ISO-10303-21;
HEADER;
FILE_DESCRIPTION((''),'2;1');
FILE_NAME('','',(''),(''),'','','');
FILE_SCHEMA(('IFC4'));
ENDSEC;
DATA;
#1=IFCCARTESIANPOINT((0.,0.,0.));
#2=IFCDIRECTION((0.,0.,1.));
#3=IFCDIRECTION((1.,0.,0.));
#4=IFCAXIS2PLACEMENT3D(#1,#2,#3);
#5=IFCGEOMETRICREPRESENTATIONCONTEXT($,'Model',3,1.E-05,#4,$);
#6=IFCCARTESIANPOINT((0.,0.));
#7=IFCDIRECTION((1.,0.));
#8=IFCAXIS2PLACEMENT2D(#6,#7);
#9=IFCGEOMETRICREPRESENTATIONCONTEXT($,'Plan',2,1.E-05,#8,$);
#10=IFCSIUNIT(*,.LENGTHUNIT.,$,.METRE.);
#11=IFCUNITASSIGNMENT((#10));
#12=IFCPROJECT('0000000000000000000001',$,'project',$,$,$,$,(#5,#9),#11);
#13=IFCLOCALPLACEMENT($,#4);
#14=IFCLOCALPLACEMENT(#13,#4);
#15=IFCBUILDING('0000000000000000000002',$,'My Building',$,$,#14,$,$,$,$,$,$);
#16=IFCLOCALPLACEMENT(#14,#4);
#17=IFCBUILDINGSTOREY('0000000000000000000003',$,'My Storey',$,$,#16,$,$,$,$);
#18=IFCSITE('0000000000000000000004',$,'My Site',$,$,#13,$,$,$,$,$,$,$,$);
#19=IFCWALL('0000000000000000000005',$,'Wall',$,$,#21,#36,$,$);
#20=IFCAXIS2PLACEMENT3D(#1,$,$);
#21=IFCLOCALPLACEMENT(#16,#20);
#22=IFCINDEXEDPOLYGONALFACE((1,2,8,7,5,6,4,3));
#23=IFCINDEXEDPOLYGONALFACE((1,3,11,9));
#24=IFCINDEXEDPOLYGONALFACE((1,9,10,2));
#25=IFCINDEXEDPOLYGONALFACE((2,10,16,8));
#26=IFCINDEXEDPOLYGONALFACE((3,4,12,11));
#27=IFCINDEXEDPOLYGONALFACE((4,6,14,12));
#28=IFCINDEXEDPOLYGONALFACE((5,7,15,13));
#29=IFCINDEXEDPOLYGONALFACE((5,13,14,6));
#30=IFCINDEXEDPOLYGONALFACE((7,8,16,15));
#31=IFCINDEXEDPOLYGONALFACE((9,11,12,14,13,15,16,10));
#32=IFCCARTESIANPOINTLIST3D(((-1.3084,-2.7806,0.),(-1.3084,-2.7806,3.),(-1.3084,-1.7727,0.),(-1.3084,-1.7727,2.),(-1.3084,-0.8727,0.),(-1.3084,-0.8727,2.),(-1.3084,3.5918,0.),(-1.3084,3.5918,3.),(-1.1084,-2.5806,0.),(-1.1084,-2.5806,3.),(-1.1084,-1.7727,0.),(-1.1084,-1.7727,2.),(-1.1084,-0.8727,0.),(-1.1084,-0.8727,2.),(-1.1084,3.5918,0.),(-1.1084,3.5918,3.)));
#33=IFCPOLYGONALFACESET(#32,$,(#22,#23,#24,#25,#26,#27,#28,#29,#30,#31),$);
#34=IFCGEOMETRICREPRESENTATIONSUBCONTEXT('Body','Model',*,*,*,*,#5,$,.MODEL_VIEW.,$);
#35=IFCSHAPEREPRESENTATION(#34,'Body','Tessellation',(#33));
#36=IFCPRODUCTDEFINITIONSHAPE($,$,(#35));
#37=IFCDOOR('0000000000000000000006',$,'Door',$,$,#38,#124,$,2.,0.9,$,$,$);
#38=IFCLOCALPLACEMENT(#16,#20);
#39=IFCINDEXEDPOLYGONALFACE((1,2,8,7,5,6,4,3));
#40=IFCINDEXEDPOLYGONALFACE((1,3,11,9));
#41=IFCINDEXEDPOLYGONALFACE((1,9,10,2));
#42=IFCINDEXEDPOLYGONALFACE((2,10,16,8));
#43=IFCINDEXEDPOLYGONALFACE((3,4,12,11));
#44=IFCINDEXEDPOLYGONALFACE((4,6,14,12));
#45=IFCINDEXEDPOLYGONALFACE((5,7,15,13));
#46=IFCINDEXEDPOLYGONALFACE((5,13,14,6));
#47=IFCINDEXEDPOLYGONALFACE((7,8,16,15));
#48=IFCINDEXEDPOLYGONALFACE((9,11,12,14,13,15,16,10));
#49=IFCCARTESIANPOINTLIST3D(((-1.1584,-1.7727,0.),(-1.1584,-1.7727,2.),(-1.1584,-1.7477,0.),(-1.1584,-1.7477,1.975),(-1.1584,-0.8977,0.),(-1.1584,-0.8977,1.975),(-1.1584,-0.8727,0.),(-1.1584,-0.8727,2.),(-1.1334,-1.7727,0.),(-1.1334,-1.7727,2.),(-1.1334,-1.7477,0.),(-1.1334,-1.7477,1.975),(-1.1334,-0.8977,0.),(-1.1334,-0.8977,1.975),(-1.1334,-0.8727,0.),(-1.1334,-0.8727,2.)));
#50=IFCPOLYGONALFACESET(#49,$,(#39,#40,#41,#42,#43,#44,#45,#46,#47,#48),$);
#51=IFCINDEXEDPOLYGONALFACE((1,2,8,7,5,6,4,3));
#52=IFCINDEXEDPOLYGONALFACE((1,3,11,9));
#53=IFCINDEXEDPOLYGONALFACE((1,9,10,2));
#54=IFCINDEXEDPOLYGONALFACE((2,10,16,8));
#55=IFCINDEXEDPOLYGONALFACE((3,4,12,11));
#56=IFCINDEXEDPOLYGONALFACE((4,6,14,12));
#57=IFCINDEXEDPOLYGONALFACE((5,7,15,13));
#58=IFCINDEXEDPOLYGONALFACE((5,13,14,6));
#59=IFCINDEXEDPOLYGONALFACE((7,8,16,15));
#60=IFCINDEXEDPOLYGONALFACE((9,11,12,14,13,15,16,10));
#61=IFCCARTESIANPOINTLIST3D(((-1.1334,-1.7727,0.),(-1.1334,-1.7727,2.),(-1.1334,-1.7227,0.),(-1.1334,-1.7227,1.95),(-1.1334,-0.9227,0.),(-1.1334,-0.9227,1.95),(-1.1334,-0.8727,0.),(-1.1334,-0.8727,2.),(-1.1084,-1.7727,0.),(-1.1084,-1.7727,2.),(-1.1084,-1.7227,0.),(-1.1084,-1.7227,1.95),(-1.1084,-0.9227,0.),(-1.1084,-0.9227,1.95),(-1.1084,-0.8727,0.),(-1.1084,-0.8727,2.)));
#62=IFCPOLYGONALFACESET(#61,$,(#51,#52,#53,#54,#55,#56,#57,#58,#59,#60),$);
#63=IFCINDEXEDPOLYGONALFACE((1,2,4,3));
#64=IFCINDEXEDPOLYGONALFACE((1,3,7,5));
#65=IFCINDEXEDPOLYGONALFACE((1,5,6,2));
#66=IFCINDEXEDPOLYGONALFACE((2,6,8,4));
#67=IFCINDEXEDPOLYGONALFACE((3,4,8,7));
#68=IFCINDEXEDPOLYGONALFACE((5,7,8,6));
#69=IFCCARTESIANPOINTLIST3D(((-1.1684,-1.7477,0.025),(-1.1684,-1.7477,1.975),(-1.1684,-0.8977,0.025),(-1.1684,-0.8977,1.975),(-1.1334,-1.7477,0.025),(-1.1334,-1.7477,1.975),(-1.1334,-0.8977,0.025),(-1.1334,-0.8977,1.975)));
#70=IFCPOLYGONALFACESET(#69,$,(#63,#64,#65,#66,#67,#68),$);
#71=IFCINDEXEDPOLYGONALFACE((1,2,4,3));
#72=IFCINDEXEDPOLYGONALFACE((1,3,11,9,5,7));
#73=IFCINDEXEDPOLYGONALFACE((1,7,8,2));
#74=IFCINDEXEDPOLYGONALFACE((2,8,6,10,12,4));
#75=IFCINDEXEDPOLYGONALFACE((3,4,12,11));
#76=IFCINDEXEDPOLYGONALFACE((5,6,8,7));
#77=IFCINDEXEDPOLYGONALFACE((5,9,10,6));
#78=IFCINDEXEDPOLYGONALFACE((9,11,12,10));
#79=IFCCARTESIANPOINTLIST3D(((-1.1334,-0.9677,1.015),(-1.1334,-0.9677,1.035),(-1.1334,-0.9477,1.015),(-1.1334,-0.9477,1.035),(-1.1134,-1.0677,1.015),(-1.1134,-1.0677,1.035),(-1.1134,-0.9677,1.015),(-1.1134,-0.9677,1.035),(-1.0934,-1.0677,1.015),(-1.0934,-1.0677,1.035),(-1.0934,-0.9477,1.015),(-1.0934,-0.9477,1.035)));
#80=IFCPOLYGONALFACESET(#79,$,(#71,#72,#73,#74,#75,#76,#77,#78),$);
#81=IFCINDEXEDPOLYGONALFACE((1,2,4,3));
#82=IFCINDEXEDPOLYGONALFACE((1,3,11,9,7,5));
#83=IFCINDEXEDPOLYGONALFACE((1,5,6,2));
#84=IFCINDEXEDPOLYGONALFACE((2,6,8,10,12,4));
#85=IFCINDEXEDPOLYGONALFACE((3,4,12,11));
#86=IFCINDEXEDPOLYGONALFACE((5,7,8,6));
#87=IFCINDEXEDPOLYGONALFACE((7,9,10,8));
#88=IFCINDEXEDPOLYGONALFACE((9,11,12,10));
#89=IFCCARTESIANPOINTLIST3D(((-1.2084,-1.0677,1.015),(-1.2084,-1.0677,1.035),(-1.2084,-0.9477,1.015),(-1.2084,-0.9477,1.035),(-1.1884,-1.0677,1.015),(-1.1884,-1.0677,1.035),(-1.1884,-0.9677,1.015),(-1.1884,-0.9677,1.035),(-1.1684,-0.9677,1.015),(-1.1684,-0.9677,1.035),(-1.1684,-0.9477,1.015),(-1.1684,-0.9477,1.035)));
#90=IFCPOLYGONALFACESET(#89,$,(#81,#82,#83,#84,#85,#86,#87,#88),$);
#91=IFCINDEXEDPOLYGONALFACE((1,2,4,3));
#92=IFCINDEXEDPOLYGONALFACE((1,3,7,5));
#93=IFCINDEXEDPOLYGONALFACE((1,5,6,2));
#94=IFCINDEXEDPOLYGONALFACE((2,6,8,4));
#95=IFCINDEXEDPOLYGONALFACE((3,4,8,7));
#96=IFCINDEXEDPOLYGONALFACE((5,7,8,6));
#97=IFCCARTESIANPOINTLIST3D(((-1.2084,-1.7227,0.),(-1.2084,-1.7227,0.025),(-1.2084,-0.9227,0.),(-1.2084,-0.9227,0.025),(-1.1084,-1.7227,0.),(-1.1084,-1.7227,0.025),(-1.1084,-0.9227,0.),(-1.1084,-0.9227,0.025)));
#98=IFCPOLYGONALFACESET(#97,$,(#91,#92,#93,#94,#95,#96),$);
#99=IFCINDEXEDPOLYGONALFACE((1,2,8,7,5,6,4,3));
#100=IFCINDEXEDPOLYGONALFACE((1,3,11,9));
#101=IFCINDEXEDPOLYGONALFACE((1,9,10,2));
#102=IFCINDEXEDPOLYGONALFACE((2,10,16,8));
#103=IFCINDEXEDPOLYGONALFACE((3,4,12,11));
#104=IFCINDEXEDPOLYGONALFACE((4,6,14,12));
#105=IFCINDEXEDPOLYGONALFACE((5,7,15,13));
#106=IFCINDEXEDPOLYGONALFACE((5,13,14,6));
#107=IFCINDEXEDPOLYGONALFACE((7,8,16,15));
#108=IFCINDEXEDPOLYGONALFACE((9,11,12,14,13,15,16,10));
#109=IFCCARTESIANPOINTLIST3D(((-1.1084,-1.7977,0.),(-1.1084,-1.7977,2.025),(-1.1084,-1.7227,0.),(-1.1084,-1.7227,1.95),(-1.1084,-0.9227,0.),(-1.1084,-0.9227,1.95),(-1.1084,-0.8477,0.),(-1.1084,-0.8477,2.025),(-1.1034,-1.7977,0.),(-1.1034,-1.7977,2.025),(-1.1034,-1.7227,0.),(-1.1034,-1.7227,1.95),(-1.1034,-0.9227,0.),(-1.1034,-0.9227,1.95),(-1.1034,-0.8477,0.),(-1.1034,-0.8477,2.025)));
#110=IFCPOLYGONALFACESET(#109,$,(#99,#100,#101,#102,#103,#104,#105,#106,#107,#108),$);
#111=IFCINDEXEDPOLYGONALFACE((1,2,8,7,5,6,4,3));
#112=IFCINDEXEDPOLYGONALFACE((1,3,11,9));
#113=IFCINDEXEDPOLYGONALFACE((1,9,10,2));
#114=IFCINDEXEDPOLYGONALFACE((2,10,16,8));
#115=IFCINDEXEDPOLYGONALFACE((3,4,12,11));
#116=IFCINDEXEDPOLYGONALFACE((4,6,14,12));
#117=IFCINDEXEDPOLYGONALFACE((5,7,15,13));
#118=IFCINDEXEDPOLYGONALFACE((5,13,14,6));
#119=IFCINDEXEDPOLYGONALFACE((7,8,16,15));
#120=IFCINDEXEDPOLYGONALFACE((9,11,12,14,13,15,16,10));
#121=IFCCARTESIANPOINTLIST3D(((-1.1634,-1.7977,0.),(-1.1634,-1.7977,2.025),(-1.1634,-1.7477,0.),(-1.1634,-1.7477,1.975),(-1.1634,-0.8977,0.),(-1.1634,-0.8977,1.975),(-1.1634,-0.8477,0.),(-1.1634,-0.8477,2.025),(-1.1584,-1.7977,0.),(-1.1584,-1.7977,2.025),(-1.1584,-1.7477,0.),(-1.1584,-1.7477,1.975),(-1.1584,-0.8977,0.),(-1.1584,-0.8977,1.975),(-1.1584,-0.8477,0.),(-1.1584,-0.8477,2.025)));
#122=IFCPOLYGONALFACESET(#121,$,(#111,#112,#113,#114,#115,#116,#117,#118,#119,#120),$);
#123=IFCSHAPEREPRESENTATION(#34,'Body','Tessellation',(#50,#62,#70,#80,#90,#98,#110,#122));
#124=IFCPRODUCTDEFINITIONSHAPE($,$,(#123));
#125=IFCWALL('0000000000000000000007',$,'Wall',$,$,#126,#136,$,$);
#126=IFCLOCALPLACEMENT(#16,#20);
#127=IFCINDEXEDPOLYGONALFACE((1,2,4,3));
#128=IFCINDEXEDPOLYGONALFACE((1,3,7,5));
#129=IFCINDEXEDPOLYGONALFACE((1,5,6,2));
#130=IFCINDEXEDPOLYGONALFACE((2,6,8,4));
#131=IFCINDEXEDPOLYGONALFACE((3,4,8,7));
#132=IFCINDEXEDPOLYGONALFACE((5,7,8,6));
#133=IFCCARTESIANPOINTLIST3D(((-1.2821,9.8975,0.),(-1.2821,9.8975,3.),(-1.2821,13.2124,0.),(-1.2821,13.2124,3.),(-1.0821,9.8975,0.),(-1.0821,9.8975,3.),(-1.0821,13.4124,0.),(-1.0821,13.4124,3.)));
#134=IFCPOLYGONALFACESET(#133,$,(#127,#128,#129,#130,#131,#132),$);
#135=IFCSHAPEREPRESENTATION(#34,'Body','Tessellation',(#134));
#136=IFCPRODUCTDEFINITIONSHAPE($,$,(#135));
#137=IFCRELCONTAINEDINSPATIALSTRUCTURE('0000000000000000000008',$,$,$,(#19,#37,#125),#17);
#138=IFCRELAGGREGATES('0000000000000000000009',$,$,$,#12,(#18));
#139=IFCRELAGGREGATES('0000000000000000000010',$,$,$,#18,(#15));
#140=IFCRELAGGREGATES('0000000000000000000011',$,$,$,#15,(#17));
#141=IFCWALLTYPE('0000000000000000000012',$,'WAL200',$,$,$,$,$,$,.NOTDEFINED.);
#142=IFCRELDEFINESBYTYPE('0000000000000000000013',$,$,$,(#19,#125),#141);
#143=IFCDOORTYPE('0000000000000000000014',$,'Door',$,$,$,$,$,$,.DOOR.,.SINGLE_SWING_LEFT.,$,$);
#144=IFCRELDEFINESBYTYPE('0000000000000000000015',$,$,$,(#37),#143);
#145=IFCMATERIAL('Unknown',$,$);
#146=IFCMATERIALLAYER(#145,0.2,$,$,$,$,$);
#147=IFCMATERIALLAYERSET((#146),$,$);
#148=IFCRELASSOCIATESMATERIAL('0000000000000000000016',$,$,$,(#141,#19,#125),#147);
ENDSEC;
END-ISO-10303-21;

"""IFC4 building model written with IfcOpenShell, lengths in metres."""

from ifc_helpers import new_model, entity, si_unit, frame, origin_with_axes, origin_2d_with_axis, place, context, subcontext, project, spatial, line, indexed_curve, outline, extrude, shape, source, transform, mapped, material, layer, layer_set, layer_usage, type_object, type_shapes, element, fill, save


model = new_model("IFC4")

# Units and contexts
model_context = context("Model", 3, precision=1e-05, world=origin_with_axes())
plan_context = context("Plan", 2, precision=1e-05, world=origin_2d_with_axis())
body_context_1 = subcontext(model_context, "Body", "Model", "MODEL_VIEW")
body_context_2 = subcontext(plan_context, "Body", "Plan", "PLAN_VIEW")
ifc_project = project(units=[si_unit("LENGTHUNIT", "METRE")], contexts=[model_context, plan_context])

# Site, building, storey
site_placement = place(None, origin_with_axes())
site = spatial("IfcSite", under=ifc_project, at=site_placement, Name="My Site")
building_placement = place(site_placement, origin_with_axes())
building = spatial("IfcBuilding", under=site, at=building_placement, Name="My Building")
storey_placement = place(building_placement, origin_with_axes())
storey = spatial("IfcBuildingStorey", under=building, at=storey_placement, Name="My Storey")

# Shared definitions
ifc_material = material(Name="Unknown")

# Shared definitions
ifc_layer = layer(ifc_material, 0.2)
ifc_layer_set = layer_set([ifc_layer])
wall_type = type_object("IfcWallType", Name="WAL200", PredefinedType="NOTDEFINED", material=ifc_layer_set)

# Shared definitions
shared_shape_1 = source(origin_with_axes(), body_context_1, "Body", "SweptSolid", [
    extrude(outline(indexed_curve([(0.0, 0.0), (0.9, 0.0), (0.9, 2.0), (0.0, 2.0)], segments=[line(1, 2, 3, 4, 1)])), frame((0.0, -0.6, 0.0), z_axis=(0.0, -1.0, 0.0), x_axis=(1.0, 0.0, 0.0)), (0.0, 0.0, -1.0), 1.2),
])
door_type = type_object("IfcDoorType", Name="Door", OperationType="SINGLE_SWING_LEFT", PredefinedType="DOOR")
shared_shape_2 = source(origin_with_axes(), body_context_1, "Body", "SweptSolid", [
    extrude(outline(indexed_curve([(0.0, 0.0), (0.0, 2.0), (0.9, 2.0), (0.9, 0.0), (0.875, 0.0), (0.875, 1.975), (0.025, 1.975), (0.025, 0.0)], segments=[line(1, 2, 3, 4, 5, 6, 7, 8, 1)])), frame((0.0, 0.025, 0.0), z_axis=(0.0, -1.0, 0.0), x_axis=(1.0, 0.0, 0.0)), (0.0, 0.0, -1.0), 0.025),
    extrude(outline(indexed_curve([(0.0, 0.0), (0.0, 2.0), (0.9, 2.0), (0.9, 0.0), (0.85, 0.0), (0.85, 1.95), (0.05, 1.95), (0.05, 0.0)], segments=[line(1, 2, 3, 4, 5, 6, 7, 8, 1)])), frame((0.0, 0.0, 0.0), z_axis=(0.0, -1.0, 0.0), x_axis=(1.0, 0.0, 0.0)), (0.0, 0.0, -1.0), 0.025),
    extrude(outline(indexed_curve([(0.0, 0.0), (0.85, 0.0), (0.85, 0.035), (0.0, 0.035)], segments=[line(1, 2, 3, 4, 1)])), frame((0.025, 0.025, 0.025), z_axis=(0.0, 0.0, 1.0), x_axis=(1.0, 0.0, 0.0)), (0.0, 0.0, 1.0), 1.95),
    extrude(outline(indexed_curve([(0.0, 0.0), (0.0, -0.04), (-0.12, -0.04), (-0.12, -0.02), (-0.02, -0.02), (-0.02, 0.0)], segments=[line(1, 2, 3, 4, 5, 6, 1)])), frame((0.825, 0.025, 1.015), z_axis=(0.0, 0.0, 1.0), x_axis=(1.0, 0.0, 0.0)), (0.0, 0.0, 1.0), 0.02),
    extrude(outline(indexed_curve([(0.0, 0.0), (0.0, 0.04), (-0.12, 0.04), (-0.12, 0.02), (-0.02, 0.02), (-0.02, 0.0)], segments=[line(1, 2, 3, 4, 5, 6, 1)])), frame((0.825, 0.06, 1.015), z_axis=(0.0, 0.0, 1.0), x_axis=(1.0, 0.0, 0.0)), (0.0, 0.0, 1.0), 0.02),
    extrude(outline(indexed_curve([(0.0, 0.0), (0.8, 0.0), (0.8, 0.1), (0.0, 0.1)], segments=[line(1, 2, 3, 4, 1)])), frame((0.05, 0.0, 0.0), z_axis=(0.0, 0.0, 1.0), x_axis=(1.0, 0.0, 0.0)), (0.0, 0.0, 1.0), 0.025),
    extrude(outline(indexed_curve([(0.0, 0.0), (0.0, 2.025), (0.95, 2.025), (0.95, 0.0), (0.875, 0.0), (0.875, 1.95), (0.075, 1.95), (0.075, 0.0)], segments=[line(1, 2, 3, 4, 5, 6, 7, 8, 1)])), frame((-0.025, -0.005, 0.0), z_axis=(0.0, -1.0, 0.0), x_axis=(1.0, 0.0, 0.0)), (0.0, 0.0, -1.0), 0.005),
    extrude(outline(indexed_curve([(0.0, 0.0), (0.0, 2.025), (0.95, 2.025), (0.95, 0.0), (0.9, 0.0), (0.9, 1.975), (0.05, 1.975), (0.05, 0.0)], segments=[line(1, 2, 3, 4, 5, 6, 7, 8, 1)])), frame((-0.025, 0.05, 0.0), z_axis=(0.0, -1.0, 0.0), x_axis=(1.0, 0.0, 0.0)), (0.0, 0.0, -1.0), 0.005),
])
shared_shape_3 = source(origin_with_axes(), body_context_2, "Body", "Curve2D", [
    entity("IfcIndexedPolyCurve", entity("IfcCartesianPointList2D", [[0.0, 0.0], [0.0, 0.05], [0.025, 0.05], [0.025, 0.025], [0.05, 0.025], [0.05, 0.0]]), [entity("IfcLineIndex", [1, 2, 3, 4, 5, 6, 1])]),
    entity("IfcIndexedPolyCurve", entity("IfcCartesianPointList2D", [[0.9, 0.0], [0.9, 0.05], [0.875, 0.05], [0.875, 0.025], [0.85, 0.025], [0.85, 0.0]]), [entity("IfcLineIndex", [1, 2, 3, 4, 5, 6, 1])]),
    entity("IfcTrimmedCurve", entity("IfcEllipse", entity("IfcAxis2Placement2D", entity("IfcCartesianPoint", [0.06, 0.05]), entity("IfcDirection", [1.0, 0.0])), 0.815, 0.85), [entity("IfcCartesianPoint", [0.875, 0.05])], [entity("IfcCartesianPoint", [0.06, 0.9])], True, "CARTESIAN"),
    entity("IfcIndexedPolyCurve", entity("IfcCartesianPointList2D", [[0.025, 0.05], [0.06, 0.05], [0.06, 0.9], [0.025, 0.9]]), [entity("IfcLineIndex", [1, 2, 3, 4, 1])]),
])
type_shapes(door_type, [shared_shape_2, shared_shape_3])

# Wall, opening, door
ifc_layer_usage_1 = layer_usage(ifc_layer_set, "AXIS2", "POSITIVE", 0.0)
wall_1_placement = place(storey_placement, frame((-1.3084, 3.5918, 0.0), z_axis=(0.0, 0.0, 1.0), x_axis=(0.0, -1.0, 0.0)))
wall_1 = element("IfcWall", 1, at=wall_1_placement, inside=storey, type_object=wall_type, material=ifc_layer_usage_1, Name="Wall", context=body_context_1, shape_type="SweptSolid", body=[
    extrude(outline(indexed_curve([(0.0, 0.0), (0.0, 0.2), (6.1724, 0.2), (6.3724, 0.0)], segments=[line(1, 2, 3, 4, 1)])), origin_with_axes(), (0.0, 0.0, 1.0), 3.0),
])
opening_1_placement = place(wall_1_placement, frame((5.3645, 0.2, 0.0), z_axis=(0.0, 0.0, 1.0), x_axis=(-1.0, 0.0, 0.0)))
opening_1 = element("IfcOpeningElement", 2, at=opening_1_placement, cuts=wall_1, PredefinedType="OPENING", context=body_context_1, shape_type="MappedRepresentation", body=[
    mapped(shared_shape_1, transform((0.0, 0.0, 0.0), x_axis=(1.0, 0.0, 0.0), y_axis=(0.0, 1.0, 0.0), z_axis=(0.0, 0.0, 1.0), scale=1.0)),
])
door_1_placement = place(opening_1_placement, frame((0.0, 0.0, 0.0), z_axis=(0.0, 0.0, 1.0), x_axis=(1.0, 0.0, 0.0)))
door_1 = element("IfcDoor", 3, at=door_1_placement, inside=storey, type_object=door_type, Name="Door", OverallHeight=2.0, OverallWidth=0.9, shapes=[
    shape(body_context_1, "Body", "MappedRepresentation", [mapped(shared_shape_2, transform((0.0, 0.0, 0.0), x_axis=(1.0, 0.0, 0.0), y_axis=(0.0, 1.0, 0.0), z_axis=(0.0, 0.0, 1.0), scale=1.0))]),
    shape(body_context_2, "Body", "MappedRepresentation", [mapped(shared_shape_3, transform((0.0, 0.0, 0.0), x_axis=(1.0, 0.0, 0.0), y_axis=(0.0, 1.0, 0.0), z_axis=(0.0, 0.0, 1.0), scale=1.0))]),
])
fill(opening_1, door_1)

# Wall
ifc_layer_usage_2 = layer_usage(ifc_layer_set, "AXIS2", "POSITIVE", 0.0)
wall_2_placement = place(storey_placement, frame((-1.2821, 13.2124, 0.0), z_axis=(0.0, 0.0, 1.0), x_axis=(0.0, -1.0, 0.0)))
element("IfcWall", 4, at=wall_2_placement, inside=storey, type_object=wall_type, material=ifc_layer_usage_2, Name="Wall", context=body_context_1, shape_type="SweptSolid", body=[
    extrude(outline(indexed_curve([(0.0, 0.0), (-0.2, 0.2), (3.3149, 0.2), (3.3149, 0.0)], segments=[line(1, 2, 3, 4, 1)])), origin_with_axes(), (0.0, 0.0, 1.0), 3.0),
])

save(model, "model.ifc")
